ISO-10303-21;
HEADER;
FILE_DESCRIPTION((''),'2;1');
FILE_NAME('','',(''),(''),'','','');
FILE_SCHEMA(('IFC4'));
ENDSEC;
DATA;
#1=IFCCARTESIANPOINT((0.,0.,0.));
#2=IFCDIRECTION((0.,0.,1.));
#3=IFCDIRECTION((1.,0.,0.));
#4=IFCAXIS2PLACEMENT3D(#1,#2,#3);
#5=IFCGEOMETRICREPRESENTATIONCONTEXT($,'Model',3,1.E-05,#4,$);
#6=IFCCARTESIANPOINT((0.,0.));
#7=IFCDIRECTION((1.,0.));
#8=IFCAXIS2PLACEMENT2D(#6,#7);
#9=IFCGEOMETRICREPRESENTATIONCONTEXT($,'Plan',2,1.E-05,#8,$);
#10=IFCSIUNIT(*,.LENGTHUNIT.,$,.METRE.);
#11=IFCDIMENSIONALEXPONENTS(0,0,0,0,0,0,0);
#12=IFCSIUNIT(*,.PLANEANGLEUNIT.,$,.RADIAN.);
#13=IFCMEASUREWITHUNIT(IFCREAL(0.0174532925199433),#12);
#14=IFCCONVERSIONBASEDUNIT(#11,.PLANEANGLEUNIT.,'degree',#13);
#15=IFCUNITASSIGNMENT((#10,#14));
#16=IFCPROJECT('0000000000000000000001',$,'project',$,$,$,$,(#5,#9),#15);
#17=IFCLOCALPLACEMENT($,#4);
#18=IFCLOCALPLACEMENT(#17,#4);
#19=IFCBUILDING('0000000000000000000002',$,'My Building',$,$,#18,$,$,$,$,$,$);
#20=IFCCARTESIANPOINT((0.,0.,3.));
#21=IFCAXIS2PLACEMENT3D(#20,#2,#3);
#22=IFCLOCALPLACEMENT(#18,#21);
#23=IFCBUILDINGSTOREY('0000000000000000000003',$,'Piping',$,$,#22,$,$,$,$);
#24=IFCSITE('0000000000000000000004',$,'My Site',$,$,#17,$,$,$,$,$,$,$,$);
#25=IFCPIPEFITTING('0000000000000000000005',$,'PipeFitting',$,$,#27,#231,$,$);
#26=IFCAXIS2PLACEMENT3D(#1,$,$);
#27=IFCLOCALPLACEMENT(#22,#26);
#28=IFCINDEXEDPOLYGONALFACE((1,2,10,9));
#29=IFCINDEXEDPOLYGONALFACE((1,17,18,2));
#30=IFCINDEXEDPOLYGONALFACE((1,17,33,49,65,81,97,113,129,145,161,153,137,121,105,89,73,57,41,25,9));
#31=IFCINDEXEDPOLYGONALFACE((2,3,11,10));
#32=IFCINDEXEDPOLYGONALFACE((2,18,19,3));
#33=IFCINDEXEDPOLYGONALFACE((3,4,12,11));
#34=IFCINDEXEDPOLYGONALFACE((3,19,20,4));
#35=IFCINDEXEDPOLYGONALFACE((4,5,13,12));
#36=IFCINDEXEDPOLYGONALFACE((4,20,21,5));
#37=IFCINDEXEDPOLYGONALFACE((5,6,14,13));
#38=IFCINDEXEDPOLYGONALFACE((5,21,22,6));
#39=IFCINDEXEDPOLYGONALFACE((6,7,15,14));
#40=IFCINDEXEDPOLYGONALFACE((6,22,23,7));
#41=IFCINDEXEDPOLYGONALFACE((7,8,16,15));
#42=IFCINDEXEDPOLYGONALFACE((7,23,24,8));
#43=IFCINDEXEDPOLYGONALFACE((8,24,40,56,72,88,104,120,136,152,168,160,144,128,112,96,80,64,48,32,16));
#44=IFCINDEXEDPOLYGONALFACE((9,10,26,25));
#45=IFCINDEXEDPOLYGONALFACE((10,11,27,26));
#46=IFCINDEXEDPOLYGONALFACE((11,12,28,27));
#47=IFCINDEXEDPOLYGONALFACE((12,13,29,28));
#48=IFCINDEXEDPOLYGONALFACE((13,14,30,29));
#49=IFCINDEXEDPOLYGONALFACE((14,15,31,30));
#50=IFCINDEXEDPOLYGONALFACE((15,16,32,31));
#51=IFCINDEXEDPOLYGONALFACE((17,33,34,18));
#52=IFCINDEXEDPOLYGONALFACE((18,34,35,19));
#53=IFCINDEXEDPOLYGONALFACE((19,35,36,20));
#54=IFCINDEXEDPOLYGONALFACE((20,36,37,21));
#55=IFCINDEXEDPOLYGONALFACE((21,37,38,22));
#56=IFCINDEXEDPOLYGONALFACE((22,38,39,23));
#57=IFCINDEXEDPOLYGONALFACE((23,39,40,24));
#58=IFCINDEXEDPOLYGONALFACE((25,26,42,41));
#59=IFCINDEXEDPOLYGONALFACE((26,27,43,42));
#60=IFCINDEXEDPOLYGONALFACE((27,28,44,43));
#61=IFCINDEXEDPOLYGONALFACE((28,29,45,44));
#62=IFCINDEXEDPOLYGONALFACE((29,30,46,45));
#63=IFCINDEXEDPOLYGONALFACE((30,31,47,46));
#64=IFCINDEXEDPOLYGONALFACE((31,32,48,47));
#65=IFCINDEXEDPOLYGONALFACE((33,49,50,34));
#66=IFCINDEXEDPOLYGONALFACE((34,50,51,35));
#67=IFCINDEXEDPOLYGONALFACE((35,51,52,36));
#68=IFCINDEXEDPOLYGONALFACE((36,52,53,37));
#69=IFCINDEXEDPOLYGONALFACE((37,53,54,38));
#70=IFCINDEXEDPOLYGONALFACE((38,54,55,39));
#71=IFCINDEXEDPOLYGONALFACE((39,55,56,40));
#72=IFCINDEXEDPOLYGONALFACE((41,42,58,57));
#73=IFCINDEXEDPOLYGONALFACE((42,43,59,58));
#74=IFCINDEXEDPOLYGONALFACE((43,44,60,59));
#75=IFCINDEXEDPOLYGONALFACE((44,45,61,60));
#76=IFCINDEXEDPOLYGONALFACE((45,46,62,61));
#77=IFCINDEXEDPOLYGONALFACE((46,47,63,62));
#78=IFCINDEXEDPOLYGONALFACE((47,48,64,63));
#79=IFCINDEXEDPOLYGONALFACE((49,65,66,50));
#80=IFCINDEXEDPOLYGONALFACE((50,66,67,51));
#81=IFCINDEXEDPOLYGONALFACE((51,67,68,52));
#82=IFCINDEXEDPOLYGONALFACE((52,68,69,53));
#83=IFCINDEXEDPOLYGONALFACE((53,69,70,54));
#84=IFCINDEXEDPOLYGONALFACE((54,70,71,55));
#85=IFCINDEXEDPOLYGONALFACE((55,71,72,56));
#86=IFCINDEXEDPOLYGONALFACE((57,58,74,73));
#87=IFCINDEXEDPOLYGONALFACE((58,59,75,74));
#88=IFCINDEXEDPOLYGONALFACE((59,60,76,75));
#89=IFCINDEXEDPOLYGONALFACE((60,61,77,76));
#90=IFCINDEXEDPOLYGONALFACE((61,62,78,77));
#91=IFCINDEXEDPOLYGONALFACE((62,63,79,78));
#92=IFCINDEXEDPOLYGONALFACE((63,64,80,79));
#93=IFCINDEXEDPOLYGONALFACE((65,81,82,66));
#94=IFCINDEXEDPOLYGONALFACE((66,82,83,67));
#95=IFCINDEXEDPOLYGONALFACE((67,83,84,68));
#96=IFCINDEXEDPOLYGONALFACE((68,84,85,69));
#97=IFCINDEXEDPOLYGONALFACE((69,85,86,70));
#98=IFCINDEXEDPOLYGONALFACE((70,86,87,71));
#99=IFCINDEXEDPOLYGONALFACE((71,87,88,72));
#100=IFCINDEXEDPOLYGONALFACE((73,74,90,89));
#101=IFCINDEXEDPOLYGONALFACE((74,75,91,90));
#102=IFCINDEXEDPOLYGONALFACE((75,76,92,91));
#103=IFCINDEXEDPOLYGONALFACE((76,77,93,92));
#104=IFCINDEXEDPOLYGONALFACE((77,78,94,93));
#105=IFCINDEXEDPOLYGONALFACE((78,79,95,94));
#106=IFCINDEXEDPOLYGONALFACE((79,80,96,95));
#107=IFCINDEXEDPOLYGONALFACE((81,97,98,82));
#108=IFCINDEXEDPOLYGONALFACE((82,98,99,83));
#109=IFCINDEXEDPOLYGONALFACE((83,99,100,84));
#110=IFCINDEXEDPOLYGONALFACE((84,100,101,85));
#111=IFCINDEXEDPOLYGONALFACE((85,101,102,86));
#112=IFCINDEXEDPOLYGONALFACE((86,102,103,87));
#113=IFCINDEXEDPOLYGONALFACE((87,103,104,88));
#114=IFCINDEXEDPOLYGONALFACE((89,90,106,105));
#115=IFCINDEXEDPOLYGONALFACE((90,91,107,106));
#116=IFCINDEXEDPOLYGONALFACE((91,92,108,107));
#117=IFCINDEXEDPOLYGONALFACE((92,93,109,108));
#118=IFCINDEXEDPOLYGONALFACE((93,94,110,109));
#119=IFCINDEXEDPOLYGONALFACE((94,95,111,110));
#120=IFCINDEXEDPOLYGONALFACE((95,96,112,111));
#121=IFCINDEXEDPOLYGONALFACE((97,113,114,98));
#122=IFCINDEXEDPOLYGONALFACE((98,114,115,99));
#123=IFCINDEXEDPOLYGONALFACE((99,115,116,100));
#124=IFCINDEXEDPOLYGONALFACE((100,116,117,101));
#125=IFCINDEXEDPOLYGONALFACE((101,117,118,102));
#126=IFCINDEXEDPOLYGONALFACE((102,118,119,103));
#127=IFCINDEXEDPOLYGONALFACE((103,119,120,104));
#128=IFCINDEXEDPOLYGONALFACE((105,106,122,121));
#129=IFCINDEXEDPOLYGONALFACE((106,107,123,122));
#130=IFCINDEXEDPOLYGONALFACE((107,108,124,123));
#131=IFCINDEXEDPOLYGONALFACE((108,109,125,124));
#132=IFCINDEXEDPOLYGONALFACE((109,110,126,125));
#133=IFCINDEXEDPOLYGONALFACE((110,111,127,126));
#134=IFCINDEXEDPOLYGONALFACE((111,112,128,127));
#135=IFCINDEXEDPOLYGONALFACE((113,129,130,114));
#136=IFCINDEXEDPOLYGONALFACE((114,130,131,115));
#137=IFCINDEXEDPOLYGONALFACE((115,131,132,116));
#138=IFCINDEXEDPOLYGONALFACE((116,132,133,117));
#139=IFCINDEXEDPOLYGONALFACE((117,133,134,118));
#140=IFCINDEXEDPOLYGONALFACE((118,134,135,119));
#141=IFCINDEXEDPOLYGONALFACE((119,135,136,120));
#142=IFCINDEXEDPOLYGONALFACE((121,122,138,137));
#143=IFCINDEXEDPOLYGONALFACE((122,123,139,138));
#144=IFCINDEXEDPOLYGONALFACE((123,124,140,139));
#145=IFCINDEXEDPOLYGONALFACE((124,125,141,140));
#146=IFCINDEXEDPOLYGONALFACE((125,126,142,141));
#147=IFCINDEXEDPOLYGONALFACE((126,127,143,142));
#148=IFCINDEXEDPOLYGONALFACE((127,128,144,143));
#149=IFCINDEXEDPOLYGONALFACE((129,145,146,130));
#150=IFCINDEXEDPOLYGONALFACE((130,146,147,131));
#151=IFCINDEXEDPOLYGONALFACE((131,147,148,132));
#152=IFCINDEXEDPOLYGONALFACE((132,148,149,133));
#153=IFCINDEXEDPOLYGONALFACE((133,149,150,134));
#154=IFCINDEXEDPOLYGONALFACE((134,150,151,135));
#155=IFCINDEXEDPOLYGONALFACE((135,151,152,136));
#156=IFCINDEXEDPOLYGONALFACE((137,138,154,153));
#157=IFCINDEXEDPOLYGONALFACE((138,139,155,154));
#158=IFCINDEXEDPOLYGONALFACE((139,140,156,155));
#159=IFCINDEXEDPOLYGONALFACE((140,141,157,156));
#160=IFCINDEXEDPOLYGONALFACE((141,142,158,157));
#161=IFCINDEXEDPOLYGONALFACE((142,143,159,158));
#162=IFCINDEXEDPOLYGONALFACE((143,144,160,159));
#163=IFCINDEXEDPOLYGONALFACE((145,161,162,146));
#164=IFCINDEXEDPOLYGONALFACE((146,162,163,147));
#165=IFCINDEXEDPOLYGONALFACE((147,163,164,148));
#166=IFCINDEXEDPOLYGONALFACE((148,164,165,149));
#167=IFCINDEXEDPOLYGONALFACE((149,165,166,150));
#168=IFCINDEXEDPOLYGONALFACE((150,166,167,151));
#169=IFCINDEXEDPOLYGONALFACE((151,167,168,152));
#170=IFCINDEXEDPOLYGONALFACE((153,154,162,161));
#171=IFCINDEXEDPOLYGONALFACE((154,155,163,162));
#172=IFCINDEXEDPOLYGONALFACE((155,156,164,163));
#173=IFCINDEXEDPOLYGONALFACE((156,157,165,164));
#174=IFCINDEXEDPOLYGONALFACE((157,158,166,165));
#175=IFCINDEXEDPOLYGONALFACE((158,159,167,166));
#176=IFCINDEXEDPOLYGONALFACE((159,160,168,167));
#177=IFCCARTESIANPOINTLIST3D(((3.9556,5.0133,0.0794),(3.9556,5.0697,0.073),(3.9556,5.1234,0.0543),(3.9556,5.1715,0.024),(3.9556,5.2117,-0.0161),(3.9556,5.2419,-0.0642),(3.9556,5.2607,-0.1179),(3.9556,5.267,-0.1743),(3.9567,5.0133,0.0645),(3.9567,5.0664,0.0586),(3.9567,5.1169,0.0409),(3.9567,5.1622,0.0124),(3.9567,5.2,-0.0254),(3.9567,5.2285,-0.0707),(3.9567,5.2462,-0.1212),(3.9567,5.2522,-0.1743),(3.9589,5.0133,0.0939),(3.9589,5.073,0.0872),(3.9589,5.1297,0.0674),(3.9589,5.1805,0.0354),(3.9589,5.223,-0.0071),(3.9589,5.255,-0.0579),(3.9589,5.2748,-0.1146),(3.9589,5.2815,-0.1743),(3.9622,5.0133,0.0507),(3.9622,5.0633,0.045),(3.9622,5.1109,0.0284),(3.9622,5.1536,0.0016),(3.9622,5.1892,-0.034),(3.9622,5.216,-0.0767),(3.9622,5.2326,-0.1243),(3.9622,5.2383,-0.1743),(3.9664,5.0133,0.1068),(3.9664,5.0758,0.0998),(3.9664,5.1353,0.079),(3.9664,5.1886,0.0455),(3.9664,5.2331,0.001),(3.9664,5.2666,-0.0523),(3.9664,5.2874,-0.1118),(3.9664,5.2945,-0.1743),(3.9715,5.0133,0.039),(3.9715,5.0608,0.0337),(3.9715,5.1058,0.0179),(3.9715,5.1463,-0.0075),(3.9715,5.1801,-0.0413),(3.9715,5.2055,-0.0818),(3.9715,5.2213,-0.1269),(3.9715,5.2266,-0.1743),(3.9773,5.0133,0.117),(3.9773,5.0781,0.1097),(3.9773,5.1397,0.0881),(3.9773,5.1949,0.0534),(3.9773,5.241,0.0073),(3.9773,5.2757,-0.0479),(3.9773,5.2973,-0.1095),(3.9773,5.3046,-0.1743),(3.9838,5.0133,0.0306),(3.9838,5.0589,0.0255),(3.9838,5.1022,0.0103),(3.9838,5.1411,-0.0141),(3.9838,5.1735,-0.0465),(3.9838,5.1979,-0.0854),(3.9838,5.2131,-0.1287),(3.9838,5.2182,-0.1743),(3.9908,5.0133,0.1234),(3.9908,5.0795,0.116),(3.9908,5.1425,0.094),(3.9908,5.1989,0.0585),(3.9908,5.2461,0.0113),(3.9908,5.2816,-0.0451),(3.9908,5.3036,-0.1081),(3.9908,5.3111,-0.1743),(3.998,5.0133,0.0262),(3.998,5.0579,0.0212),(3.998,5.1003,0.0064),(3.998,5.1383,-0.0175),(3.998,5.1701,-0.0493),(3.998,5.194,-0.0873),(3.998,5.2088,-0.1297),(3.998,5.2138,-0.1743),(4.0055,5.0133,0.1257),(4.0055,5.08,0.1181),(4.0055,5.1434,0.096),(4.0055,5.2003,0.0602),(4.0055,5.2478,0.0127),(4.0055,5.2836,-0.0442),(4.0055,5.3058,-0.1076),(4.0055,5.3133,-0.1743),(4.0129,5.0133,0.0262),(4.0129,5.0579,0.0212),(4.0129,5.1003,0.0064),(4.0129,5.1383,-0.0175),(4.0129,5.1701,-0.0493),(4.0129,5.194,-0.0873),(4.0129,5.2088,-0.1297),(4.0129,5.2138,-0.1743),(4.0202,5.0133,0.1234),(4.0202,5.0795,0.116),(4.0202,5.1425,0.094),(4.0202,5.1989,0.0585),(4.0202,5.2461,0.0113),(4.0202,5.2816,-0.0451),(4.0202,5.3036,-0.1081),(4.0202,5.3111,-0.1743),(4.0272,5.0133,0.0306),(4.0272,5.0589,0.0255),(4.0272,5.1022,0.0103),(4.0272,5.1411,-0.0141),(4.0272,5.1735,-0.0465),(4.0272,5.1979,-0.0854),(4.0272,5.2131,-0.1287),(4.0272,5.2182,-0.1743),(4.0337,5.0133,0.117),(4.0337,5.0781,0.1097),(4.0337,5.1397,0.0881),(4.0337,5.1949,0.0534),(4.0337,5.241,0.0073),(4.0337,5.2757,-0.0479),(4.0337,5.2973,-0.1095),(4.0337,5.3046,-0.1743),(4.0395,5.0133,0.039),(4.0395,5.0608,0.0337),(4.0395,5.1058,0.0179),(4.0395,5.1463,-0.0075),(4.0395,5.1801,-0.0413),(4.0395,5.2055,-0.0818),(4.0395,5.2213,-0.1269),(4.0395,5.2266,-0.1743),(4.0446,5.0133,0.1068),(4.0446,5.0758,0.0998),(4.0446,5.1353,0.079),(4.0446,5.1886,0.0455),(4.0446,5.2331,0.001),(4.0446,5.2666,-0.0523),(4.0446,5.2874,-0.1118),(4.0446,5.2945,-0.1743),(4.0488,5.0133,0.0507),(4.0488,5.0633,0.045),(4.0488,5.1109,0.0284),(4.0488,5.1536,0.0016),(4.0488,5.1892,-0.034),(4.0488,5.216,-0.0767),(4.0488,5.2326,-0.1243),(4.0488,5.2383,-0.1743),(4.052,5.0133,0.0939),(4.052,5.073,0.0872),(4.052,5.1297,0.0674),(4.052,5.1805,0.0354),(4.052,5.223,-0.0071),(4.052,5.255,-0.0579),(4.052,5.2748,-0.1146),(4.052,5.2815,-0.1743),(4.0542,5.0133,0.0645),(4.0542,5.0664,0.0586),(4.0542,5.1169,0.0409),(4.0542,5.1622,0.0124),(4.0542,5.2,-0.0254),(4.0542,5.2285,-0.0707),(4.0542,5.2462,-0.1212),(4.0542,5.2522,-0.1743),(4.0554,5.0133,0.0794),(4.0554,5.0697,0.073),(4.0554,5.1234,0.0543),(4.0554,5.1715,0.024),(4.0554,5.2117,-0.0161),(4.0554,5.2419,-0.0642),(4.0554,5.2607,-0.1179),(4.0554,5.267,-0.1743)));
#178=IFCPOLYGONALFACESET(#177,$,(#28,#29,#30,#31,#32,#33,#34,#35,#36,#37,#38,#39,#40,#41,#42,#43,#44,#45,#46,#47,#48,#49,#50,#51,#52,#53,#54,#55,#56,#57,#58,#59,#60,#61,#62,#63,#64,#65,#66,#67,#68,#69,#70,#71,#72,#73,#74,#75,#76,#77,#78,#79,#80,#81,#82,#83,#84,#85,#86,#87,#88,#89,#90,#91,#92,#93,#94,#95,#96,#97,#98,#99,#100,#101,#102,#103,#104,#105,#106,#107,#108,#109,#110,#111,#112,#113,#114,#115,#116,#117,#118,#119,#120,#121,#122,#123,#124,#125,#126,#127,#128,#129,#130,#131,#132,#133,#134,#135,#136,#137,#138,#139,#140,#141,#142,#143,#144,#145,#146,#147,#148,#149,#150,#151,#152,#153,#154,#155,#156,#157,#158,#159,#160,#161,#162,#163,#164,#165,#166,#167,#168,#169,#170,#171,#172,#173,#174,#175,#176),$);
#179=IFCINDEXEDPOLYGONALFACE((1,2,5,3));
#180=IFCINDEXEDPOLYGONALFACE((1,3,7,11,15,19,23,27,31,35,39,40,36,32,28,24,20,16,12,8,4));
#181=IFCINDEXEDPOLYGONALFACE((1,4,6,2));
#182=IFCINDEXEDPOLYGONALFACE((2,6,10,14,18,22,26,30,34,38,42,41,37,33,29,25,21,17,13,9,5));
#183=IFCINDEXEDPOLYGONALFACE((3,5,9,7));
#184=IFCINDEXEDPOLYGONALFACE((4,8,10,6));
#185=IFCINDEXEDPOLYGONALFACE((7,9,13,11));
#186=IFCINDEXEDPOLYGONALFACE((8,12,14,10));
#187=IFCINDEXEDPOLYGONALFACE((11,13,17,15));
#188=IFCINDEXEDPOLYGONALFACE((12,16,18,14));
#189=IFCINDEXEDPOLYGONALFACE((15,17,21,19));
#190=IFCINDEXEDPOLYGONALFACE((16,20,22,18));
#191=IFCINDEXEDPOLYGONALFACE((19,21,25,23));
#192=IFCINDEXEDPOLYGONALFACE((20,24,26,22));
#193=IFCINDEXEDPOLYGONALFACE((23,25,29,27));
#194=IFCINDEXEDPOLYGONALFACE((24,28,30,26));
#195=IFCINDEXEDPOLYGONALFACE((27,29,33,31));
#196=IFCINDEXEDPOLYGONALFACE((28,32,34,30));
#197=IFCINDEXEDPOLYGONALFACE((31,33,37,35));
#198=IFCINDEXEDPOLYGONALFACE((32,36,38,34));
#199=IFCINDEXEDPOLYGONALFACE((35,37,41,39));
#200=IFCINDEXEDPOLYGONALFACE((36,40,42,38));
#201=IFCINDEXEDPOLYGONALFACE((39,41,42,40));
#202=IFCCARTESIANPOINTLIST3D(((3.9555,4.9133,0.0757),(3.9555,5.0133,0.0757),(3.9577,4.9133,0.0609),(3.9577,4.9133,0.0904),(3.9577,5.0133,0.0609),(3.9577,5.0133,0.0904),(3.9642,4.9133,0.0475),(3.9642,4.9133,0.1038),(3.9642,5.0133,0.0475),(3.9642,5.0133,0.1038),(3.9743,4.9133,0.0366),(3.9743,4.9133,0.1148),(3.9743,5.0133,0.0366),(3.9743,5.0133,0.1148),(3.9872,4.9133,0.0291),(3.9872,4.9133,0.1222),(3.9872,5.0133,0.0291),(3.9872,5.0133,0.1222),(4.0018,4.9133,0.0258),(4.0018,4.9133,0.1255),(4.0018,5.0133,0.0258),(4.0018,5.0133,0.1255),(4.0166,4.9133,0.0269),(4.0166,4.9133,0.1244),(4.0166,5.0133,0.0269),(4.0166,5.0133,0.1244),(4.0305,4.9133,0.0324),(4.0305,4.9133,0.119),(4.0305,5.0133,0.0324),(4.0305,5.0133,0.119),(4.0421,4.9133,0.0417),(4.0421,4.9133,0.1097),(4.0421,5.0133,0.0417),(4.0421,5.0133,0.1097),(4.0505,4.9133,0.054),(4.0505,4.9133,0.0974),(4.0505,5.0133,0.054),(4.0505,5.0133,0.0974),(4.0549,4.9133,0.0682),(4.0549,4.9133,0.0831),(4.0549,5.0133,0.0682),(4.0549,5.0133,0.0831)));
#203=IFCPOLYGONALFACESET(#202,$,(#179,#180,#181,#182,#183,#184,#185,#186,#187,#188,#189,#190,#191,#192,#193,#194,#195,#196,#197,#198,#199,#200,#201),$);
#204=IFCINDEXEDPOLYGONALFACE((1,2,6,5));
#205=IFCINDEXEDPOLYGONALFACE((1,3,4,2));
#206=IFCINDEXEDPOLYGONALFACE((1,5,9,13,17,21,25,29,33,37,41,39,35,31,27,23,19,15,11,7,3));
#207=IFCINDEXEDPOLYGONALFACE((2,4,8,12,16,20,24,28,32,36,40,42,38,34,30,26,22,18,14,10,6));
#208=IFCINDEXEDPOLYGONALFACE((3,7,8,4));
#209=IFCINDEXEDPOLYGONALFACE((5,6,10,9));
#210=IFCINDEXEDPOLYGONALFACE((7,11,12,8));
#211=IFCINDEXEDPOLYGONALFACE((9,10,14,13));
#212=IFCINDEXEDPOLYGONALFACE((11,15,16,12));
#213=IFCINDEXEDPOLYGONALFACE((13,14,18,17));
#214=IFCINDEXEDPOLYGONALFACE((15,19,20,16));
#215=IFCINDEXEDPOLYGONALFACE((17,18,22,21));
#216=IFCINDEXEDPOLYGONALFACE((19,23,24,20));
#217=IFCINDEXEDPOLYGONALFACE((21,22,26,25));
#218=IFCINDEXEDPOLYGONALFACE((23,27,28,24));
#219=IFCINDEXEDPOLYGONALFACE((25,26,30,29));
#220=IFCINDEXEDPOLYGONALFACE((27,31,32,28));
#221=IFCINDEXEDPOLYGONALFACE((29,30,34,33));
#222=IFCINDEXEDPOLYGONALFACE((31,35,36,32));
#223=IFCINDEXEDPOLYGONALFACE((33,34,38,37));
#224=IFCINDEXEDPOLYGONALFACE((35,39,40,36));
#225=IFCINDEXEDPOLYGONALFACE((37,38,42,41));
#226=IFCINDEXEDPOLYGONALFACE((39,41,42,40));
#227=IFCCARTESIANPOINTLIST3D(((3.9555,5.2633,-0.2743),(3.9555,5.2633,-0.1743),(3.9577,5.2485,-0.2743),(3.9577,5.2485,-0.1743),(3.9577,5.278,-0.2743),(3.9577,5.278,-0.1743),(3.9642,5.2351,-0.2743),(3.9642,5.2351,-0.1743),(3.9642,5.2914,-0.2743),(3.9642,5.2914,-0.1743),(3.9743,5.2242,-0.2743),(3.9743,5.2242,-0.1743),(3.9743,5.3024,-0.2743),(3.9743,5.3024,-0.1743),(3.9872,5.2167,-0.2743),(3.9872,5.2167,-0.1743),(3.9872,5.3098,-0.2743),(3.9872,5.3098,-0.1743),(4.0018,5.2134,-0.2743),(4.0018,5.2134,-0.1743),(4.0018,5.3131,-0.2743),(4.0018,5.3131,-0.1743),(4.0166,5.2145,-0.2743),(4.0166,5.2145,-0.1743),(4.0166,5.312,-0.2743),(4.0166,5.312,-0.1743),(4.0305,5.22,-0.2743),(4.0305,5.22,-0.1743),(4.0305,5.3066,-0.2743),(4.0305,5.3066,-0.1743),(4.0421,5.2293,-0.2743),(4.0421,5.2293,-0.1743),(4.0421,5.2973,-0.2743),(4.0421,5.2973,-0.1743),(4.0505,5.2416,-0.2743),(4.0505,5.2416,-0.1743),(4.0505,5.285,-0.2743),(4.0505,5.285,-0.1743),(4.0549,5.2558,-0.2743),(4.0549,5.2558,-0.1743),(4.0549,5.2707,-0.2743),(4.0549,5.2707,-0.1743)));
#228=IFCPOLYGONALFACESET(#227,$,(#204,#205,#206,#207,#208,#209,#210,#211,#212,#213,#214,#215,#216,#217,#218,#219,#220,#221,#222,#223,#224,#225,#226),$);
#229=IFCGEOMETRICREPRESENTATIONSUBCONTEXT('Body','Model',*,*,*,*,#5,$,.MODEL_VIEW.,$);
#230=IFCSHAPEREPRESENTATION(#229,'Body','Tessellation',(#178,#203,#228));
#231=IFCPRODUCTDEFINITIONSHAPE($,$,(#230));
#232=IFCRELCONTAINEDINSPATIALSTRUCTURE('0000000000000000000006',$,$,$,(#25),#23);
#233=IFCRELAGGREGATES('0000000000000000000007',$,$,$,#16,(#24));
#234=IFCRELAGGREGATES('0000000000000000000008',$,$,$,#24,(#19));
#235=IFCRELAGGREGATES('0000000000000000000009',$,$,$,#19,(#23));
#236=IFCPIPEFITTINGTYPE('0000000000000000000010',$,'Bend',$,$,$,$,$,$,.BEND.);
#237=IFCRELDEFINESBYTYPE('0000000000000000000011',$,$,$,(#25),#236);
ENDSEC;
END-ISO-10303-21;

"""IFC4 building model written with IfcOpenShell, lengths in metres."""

from ifc_helpers import new_model, entity, si_unit, converted_unit, frame, origin_with_axes, origin_2d_with_axis, place, context, subcontext, project, spatial, circle, extrude, source, transform, mapped, type_object, type_shapes, element, save


model = new_model("IFC4")

# Units and contexts
model_context = context("Model", 3, precision=1e-05, world=origin_with_axes())
plan_context = context("Plan", 2, precision=1e-05, world=origin_2d_with_axis())
body_context = subcontext(model_context, "Body", "Model", "MODEL_VIEW")
ifc_project = project(units=[si_unit("LENGTHUNIT", "METRE"), converted_unit("PLANEANGLEUNIT", "degree", entity("IfcReal", 0.0174532925199433), si_unit("PLANEANGLEUNIT", "RADIAN"), dimensions=[0, 0, 0, 0, 0, 0, 0])], contexts=[model_context, plan_context])

# Site, building, storey
site_placement = place(None, origin_with_axes())
site = spatial("IfcSite", under=ifc_project, at=site_placement, Name="My Site")
building_placement = place(site_placement, origin_with_axes())
building = spatial("IfcBuilding", under=site, at=building_placement, Name="My Building")
storey_placement = place(building_placement, frame((0.0, 0.0, 3.0), z_axis=(0.0, 0.0, 1.0), x_axis=(1.0, 0.0, 0.0)))
storey = spatial("IfcBuildingStorey", under=building, at=storey_placement, Name="Piping")

# Pipe fitting
pipe_fitting_type_1 = type_object("IfcPipeFittingType", Name="Bend", PredefinedType="BEND")
shared_shape_1 = source(origin_with_axes(), body_context, "Body", "SolidModel", [
    entity("IfcSweptDiskSolid", entity("IfcIndexedPolyCurve", entity("IfcCartesianPointList3D", [[0.0, 0.0, 0.1], [0.0, -0.0732, 0.2768], [0.0, -0.25, 0.35]]), [entity("IfcArcIndex", [1, 2, 3])]), 0.05),
    extrude(circle(Radius=0.05), origin_with_axes(), (0.0, 0.0, 1.0), 0.1),
    extrude(circle(Radius=0.05), frame((0.0, -0.25, 0.35), z_axis=(0.0, -1.0, 0.0), x_axis=(1.0, 0.0, 0.0)), (0.0, 0.0, 1.0), 0.1),
])
type_shapes(pipe_fitting_type_1, [shared_shape_1])
for number, where, z_axis, x_axis, name in (
    (1, (4.0055, 4.9133, 0.0757), (0.0, 1.0, 0.0), (-1.0, 0.0, 0.0), "PipeFitting"),
):
    element("IfcPipeFitting", number, at=place(storey_placement, frame(where, z_axis=z_axis, x_axis=x_axis)), inside=storey, type_object=pipe_fitting_type_1, Name=name, context=body_context, shape_type="MappedRepresentation", body=[
        mapped(shared_shape_1, transform((0.0, 0.0, 0.0), x_axis=(1.0, 0.0, 0.0), y_axis=(0.0, 1.0, 0.0), z_axis=(0.0, 0.0, 1.0), scale=1.0)),
    ])

save(model, "model.ifc")
